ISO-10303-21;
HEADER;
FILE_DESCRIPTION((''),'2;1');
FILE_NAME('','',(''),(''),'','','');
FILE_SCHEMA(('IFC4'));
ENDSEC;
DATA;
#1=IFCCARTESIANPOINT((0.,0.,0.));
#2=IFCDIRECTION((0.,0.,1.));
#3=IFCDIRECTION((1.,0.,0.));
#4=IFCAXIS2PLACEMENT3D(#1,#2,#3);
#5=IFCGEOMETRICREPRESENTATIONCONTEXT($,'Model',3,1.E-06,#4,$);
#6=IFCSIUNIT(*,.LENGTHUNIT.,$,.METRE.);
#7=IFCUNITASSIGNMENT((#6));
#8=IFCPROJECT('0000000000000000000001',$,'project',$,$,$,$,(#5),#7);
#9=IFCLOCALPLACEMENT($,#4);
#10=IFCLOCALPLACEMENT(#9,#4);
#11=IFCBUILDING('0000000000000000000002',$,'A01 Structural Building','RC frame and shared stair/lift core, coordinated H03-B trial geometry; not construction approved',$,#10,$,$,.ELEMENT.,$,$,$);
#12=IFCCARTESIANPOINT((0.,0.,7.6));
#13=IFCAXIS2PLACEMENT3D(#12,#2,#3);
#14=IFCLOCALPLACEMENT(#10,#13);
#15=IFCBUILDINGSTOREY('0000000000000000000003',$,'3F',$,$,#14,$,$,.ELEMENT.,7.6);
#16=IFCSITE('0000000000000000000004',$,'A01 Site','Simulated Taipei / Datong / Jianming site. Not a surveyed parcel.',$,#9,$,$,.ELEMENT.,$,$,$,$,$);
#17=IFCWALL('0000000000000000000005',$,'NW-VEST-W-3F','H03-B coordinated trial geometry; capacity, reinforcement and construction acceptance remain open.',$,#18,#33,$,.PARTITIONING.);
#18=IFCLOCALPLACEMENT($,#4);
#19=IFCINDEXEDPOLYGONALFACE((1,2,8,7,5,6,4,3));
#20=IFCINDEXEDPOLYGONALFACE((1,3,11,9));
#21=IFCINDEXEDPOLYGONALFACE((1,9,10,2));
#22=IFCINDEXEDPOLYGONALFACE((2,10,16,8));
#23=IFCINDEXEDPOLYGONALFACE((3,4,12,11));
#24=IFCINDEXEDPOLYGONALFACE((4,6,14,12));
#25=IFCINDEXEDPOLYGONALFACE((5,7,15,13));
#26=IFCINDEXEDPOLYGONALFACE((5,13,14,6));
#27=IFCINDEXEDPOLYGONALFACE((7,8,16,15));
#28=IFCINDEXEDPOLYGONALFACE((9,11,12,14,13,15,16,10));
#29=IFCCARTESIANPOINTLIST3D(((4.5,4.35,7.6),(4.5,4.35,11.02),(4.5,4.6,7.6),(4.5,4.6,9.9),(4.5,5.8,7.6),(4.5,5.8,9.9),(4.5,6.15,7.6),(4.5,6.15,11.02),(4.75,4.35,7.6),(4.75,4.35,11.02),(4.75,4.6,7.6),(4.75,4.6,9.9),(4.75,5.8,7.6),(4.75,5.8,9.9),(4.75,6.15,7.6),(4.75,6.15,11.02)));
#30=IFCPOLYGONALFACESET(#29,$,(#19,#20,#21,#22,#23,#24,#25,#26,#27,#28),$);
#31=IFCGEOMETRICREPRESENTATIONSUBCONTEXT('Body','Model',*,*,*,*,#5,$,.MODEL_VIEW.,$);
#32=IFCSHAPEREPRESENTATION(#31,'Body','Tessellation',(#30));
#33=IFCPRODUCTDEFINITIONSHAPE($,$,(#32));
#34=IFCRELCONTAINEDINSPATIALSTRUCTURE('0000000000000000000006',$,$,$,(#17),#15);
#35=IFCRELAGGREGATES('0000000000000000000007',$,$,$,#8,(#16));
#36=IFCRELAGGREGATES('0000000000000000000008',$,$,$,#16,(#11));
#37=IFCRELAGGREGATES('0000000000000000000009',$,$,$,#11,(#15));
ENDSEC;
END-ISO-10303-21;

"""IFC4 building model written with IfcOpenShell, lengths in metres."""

from ifc_helpers import new_model, si_unit, frame, origin_with_axes, place, context, subcontext, project, spatial, polyline, outline, extrude, element, save


model = new_model("IFC4")

# Units and contexts
model_context = context("Model", 3, precision=1e-06, world=origin_with_axes())
body_context = subcontext(model_context, "Body", "Model", "MODEL_VIEW")
ifc_project = project(units=[si_unit("LENGTHUNIT", "METRE")], contexts=[model_context])

# Site, building, storey
site_placement = place(None, origin_with_axes())
site = spatial("IfcSite", under=ifc_project, at=site_placement, Name="A01 Site", Description="Simulated Taipei / Datong / Jianming site. Not a surveyed parcel.", CompositionType="ELEMENT")
building_placement = place(site_placement, origin_with_axes())
building = spatial("IfcBuilding", under=site, at=building_placement, Name="A01 Structural Building", Description="RC frame and shared stair/lift core, coordinated H03-B trial geometry; not construction approved", CompositionType="ELEMENT")
storey_placement = place(building_placement, frame((0.0, 0.0, 7.6), z_axis=(0.0, 0.0, 1.0), x_axis=(1.0, 0.0, 0.0)))
storey = spatial("IfcBuildingStorey", under=building, at=storey_placement, Name="3F", CompositionType="ELEMENT", Elevation=7.6)

# Shared definitions
placement = place(None, origin_with_axes())

# Wall, opening
wall_1 = element("IfcWall", 1, at=placement, inside=storey, Name="NW-VEST-W-3F", Description="H03-B coordinated trial geometry; capacity, reinforcement and construction acceptance remain open.", PredefinedType="PARTITIONING", context=body_context, shape_type="SweptSolid", body=[
    extrude(outline(polyline([(4.75, 4.35), (4.75, 6.15), (4.5, 6.15), (4.5, 4.35), (4.75, 4.35)])), frame((0.0, 0.0, 7.6), z_axis=(0.0, 0.0, 1.0), x_axis=(1.0, 0.0, 0.0)), (0.0, 0.0, 1.0), 3.42),
])
element("IfcOpeningElement", 2, at=placement, cuts=wall_1, PredefinedType="OPENING", context=body_context, shape_type="SweptSolid", body=[
    extrude(outline(polyline([(4.8, 4.6), (4.8, 5.8), (4.45, 5.8), (4.45, 4.6), (4.8, 4.6)])), frame((0.0, 0.0, 7.6), z_axis=(0.0, 0.0, 1.0), x_axis=(1.0, 0.0, 0.0)), (0.0, 0.0, 1.0), 2.3),
])

save(model, "model.ifc")
